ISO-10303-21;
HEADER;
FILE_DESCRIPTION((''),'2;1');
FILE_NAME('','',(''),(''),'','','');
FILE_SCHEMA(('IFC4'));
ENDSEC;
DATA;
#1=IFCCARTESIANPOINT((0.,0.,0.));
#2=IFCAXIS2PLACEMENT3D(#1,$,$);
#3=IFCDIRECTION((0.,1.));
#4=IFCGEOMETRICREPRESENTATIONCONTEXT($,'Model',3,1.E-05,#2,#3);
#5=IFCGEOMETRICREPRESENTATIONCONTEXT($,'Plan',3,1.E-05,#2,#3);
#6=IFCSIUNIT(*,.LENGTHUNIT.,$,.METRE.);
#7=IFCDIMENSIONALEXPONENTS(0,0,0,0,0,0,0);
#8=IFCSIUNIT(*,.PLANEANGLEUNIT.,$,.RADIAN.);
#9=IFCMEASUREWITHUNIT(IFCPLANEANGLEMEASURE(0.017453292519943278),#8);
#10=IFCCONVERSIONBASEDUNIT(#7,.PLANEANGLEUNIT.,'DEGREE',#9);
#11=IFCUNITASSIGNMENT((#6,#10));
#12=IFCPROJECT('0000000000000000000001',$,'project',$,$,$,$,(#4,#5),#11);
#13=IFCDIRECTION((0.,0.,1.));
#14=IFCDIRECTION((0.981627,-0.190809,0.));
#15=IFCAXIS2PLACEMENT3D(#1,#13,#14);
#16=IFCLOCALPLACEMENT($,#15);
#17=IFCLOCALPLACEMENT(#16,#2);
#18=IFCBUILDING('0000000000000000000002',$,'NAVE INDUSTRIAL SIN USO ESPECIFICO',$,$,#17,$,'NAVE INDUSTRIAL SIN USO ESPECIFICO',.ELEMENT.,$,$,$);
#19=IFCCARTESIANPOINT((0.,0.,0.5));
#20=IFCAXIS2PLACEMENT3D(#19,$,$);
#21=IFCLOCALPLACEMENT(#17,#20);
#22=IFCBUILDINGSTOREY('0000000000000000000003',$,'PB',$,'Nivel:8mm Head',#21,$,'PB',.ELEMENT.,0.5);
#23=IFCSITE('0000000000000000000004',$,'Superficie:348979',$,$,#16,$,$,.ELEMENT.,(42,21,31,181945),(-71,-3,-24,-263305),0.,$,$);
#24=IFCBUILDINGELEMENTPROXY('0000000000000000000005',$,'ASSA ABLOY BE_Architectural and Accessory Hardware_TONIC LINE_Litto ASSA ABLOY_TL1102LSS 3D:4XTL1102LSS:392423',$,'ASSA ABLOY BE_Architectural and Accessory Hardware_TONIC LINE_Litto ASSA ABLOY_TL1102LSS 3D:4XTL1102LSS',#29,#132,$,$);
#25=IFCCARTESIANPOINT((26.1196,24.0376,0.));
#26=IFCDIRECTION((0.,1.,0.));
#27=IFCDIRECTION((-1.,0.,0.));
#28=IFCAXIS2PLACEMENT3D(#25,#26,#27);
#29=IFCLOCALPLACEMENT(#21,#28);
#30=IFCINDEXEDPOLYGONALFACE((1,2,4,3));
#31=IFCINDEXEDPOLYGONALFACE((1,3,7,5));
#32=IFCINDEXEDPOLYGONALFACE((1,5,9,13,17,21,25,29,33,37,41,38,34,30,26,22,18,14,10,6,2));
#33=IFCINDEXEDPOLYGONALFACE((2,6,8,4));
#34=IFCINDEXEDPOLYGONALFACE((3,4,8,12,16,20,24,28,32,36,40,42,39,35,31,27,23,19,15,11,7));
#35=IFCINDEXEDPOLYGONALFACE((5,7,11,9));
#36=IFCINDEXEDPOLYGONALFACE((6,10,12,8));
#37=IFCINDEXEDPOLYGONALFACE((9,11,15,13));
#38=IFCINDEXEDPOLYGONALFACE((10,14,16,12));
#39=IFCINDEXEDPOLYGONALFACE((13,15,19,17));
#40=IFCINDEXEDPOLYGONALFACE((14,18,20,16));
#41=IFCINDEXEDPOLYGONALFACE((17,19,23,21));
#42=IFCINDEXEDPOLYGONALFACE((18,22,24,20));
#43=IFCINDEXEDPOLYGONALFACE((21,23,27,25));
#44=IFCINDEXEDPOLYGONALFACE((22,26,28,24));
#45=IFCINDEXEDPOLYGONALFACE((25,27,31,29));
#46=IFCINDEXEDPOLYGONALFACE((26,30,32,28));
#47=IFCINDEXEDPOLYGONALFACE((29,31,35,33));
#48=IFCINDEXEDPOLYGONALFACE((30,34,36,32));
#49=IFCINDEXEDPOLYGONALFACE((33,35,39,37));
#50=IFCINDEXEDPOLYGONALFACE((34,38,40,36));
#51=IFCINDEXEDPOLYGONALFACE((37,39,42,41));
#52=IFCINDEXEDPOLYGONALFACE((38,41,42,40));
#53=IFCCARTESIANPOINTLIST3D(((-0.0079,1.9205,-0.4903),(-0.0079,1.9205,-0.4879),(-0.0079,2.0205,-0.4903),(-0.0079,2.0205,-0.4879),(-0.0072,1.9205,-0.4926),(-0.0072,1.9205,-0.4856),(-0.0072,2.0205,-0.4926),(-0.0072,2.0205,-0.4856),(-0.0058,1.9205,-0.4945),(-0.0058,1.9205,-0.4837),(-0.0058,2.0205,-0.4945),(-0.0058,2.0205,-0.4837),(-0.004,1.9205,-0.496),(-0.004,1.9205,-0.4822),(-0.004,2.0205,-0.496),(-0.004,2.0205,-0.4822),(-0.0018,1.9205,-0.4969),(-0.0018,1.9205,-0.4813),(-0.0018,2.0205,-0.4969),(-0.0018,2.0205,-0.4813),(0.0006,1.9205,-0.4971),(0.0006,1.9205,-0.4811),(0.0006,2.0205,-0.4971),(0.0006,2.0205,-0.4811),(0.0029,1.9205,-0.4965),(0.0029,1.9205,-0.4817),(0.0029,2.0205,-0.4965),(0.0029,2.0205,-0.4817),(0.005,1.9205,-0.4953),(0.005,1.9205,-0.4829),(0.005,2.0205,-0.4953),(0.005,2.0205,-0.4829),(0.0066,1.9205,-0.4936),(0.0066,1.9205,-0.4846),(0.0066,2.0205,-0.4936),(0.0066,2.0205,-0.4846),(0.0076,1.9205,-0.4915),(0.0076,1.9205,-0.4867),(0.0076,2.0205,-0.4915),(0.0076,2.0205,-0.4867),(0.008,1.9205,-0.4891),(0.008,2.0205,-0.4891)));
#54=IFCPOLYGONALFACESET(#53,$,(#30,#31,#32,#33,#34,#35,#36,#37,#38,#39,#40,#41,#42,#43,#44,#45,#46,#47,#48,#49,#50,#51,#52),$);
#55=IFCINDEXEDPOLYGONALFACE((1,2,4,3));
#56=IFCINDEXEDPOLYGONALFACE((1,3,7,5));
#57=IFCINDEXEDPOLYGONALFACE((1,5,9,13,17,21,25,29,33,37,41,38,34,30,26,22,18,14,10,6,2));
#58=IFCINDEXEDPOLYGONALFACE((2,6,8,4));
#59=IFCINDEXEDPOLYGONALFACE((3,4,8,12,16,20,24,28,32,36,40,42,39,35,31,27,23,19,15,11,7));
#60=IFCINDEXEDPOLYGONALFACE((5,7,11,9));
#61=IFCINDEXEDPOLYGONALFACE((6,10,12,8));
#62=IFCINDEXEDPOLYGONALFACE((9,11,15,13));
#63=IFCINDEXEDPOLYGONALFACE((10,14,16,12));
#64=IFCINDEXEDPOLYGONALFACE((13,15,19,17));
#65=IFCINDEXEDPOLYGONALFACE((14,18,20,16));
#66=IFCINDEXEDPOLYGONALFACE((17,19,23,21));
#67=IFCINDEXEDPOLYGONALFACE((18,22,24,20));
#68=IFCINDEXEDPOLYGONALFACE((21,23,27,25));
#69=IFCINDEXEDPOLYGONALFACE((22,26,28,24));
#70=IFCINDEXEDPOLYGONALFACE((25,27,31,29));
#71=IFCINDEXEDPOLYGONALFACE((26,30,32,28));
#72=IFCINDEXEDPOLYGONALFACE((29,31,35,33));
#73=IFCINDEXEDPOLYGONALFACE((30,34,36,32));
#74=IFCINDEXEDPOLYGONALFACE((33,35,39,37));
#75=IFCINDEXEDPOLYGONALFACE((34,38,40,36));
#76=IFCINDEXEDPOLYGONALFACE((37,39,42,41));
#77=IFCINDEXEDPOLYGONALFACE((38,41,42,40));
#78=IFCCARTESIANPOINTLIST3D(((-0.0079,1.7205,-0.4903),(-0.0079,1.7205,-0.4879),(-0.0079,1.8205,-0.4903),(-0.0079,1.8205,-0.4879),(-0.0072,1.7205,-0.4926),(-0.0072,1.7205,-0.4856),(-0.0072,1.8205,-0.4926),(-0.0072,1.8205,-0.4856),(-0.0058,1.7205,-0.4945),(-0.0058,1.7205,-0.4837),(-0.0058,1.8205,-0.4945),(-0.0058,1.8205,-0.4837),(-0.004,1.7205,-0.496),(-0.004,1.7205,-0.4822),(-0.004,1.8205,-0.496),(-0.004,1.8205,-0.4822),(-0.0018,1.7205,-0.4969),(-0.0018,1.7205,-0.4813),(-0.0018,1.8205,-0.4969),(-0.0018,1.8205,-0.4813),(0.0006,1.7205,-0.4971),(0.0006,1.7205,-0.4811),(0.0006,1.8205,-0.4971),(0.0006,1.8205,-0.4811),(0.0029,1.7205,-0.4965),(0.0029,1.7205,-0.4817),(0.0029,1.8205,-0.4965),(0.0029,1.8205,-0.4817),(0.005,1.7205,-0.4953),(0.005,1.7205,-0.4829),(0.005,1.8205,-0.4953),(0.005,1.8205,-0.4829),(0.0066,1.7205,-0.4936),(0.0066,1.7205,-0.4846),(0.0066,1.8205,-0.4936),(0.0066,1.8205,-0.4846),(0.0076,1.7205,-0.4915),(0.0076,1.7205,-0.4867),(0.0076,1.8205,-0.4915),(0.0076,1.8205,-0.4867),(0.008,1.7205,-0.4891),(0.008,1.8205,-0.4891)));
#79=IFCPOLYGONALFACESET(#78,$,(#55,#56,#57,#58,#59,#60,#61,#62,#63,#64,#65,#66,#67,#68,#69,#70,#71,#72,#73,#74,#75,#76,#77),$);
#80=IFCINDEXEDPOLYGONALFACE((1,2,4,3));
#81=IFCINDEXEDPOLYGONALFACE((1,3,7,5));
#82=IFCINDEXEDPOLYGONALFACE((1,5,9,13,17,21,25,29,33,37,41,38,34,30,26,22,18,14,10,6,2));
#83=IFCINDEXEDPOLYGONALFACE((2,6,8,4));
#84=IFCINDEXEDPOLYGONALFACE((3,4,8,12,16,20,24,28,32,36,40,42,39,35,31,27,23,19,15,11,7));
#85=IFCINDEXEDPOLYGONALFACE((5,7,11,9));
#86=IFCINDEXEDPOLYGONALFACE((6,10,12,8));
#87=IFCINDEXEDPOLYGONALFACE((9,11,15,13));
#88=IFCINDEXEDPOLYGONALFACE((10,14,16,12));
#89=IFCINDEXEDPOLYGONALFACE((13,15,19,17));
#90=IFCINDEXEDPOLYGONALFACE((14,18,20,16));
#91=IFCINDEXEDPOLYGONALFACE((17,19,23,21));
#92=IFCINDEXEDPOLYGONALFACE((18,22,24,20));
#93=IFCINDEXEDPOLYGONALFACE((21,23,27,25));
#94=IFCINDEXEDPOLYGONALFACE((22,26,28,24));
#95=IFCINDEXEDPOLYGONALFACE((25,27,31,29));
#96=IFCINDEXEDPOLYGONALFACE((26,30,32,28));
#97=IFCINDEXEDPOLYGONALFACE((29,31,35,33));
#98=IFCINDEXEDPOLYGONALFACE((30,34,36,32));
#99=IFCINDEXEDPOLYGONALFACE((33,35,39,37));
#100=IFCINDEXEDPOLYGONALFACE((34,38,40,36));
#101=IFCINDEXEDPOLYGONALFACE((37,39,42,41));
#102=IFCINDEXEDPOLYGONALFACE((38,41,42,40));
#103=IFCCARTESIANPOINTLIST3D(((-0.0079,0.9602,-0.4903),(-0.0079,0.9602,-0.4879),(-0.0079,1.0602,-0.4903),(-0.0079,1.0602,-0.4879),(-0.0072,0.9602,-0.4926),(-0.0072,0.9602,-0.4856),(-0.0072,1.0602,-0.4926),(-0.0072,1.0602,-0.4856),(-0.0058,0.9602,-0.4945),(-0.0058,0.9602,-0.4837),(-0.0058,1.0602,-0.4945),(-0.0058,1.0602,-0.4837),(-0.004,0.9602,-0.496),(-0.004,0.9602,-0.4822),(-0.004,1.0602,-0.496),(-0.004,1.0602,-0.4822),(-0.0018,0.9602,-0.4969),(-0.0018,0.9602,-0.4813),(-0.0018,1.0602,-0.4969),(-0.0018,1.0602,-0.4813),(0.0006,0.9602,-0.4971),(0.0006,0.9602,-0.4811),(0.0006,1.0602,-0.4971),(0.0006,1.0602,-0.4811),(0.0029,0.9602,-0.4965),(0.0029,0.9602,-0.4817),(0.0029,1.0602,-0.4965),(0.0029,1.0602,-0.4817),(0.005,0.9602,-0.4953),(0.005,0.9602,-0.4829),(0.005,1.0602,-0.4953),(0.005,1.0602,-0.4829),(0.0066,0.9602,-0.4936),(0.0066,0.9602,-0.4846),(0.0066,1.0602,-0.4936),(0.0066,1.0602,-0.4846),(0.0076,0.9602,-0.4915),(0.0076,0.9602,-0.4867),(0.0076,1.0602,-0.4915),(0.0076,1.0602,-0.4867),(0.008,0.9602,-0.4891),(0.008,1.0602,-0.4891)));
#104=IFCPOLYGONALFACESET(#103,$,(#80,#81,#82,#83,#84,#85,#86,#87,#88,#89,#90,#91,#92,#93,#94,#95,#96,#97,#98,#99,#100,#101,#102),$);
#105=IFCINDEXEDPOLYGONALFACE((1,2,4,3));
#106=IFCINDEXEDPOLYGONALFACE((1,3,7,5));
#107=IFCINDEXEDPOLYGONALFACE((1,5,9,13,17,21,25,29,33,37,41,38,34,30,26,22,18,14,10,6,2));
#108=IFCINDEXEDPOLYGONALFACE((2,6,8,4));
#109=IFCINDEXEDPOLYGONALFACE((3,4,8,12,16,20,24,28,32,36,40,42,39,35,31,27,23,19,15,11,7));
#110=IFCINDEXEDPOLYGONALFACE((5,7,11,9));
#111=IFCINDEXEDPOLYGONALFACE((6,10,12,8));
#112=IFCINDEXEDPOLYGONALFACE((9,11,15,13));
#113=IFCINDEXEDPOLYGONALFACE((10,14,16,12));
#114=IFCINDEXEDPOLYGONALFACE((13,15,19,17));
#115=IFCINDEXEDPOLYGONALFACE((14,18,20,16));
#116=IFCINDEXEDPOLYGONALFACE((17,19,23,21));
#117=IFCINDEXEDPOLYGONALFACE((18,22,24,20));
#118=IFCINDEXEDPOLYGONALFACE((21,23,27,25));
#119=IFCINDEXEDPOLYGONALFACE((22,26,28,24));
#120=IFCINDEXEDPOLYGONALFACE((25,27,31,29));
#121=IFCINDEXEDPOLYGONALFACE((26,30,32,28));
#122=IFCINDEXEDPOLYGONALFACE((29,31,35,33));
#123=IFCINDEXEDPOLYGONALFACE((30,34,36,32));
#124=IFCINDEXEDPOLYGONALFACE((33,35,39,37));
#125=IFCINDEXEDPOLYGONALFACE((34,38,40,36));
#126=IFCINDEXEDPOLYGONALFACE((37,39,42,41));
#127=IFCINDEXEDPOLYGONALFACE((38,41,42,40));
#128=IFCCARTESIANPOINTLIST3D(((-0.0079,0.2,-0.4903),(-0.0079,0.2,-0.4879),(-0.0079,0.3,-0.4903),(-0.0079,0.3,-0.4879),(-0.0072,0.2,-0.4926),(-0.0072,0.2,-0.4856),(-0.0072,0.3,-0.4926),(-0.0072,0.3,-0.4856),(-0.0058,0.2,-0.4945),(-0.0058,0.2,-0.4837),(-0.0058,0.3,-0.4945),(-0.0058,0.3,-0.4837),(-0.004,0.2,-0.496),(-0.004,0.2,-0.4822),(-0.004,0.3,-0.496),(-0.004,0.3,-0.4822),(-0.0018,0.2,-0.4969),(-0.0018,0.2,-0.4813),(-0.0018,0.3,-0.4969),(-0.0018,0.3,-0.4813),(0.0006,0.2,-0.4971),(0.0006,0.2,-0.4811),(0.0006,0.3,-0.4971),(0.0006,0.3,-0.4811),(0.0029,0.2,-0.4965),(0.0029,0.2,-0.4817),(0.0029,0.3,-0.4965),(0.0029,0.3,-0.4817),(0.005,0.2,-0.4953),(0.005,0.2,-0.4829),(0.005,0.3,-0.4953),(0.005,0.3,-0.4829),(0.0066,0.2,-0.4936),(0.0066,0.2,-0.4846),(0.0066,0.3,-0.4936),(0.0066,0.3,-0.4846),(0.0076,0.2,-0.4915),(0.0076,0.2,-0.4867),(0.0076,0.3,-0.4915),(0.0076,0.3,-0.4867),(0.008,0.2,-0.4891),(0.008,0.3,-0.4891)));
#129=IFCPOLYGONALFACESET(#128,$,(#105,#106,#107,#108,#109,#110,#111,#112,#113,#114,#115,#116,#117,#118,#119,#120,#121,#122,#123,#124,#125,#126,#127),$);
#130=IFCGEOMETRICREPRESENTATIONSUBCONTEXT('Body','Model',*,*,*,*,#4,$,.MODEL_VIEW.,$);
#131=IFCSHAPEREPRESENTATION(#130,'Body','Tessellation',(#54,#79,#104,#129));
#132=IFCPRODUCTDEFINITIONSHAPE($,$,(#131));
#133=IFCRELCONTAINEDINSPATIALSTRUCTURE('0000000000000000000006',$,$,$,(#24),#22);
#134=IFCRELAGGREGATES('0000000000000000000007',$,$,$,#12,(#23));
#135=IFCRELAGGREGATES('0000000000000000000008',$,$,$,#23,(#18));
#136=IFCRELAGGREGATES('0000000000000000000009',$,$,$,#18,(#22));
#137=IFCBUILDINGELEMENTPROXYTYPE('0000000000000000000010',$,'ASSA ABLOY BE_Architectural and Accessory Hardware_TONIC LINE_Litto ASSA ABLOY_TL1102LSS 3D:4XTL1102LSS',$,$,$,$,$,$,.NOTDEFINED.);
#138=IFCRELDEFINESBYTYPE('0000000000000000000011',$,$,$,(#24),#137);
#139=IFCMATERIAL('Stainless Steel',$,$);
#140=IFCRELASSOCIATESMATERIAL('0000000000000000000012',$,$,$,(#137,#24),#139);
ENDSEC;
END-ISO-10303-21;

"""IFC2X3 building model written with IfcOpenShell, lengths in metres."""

from ifc_helpers import new_model, entity, si_unit, converted_unit, direction, frame, frame_2d, origin, place, context, subcontext, project, spatial, circle, extrude, source, transform, mapped, material, type_object, type_shapes, element, save


model = new_model("IFC2X3")

# Units and contexts
model_context = context("Model", 3, precision=1e-05, world=origin(), true_north=direction((0.0, 1.0)))
plan_context = context("Plan", 3, precision=1e-05, world=origin(), true_north=direction((0.0, 1.0)))
body_context = subcontext(model_context, "Body", "Model", "MODEL_VIEW")
ifc_project = project(units=[si_unit("LENGTHUNIT", "METRE"), converted_unit("PLANEANGLEUNIT", "DEGREE", entity("IfcPlaneAngleMeasure", 0.017453292519943278), si_unit("PLANEANGLEUNIT", "RADIAN"), dimensions=[0, 0, 0, 0, 0, 0, 0])], contexts=[model_context, plan_context])

# Site, building, storey
site_placement = place(None, frame((0.0, 0.0, 0.0), z_axis=(0.0, 0.0, 1.0), x_axis=(0.981627, -0.190809, 0.0)))
site = spatial("IfcSite", under=ifc_project, at=site_placement, Name="Superficie:348979", CompositionType="ELEMENT", RefLatitude=(42, 21, 31, 181945), RefLongitude=(-71, -3, -24, -263305), RefElevation=0.0)
building_placement = place(site_placement, origin())
building = spatial("IfcBuilding", under=site, at=building_placement, Name="NAVE INDUSTRIAL SIN USO ESPECIFICO", LongName="NAVE INDUSTRIAL SIN USO ESPECIFICO", CompositionType="ELEMENT")
storey_placement = place(building_placement, frame((0.0, 0.0, 0.5)))
storey = spatial("IfcBuildingStorey", under=building, at=storey_placement, Name="PB", ObjectType="Nivel:8mm Head", LongName="PB", CompositionType="ELEMENT", Elevation=0.5)

# Building element proxy
ifc_material_1 = material(Name="Stainless Steel")
building_element_proxy_type_1 = type_object("IfcBuildingElementProxyType", Name="ASSA ABLOY BE_Architectural and Accessory Hardware_TONIC LINE_Litto ASSA ABLOY_TL1102LSS 3D:4XTL1102LSS", PredefinedType="NOTDEFINED", material=ifc_material_1)
shared_shape_1 = source(origin(), body_context, "Body", "SweptSolid", [
    extrude(circle(Radius=0.008, at=frame_2d((0.0, 0.0), x_axis=(1.0, 0.0))), frame((0.0, 1.9205, -0.4891), z_axis=(0.0, 1.0, 0.0), x_axis=(1.0, 0.0, 0.0)), (0.0, 0.0, 1.0), 0.1),
    extrude(circle(Radius=0.008, at=frame_2d((0.0, 0.0), x_axis=(1.0, 0.0))), frame((0.0, 1.7205, -0.4891), z_axis=(0.0, 1.0, 0.0), x_axis=(1.0, 0.0, 0.0)), (0.0, 0.0, 1.0), 0.1),
    extrude(circle(Radius=0.008, at=frame_2d((0.0, 0.0), x_axis=(1.0, 0.0))), frame((0.0, 0.9602, -0.4891), z_axis=(0.0, 1.0, 0.0), x_axis=(1.0, 0.0, 0.0)), (0.0, 0.0, 1.0), 0.1),
    extrude(circle(Radius=0.008, at=frame_2d((0.0, 0.0), x_axis=(1.0, 0.0))), frame((0.0, 0.2, -0.4891), z_axis=(0.0, 1.0, 0.0), x_axis=(1.0, 0.0, 0.0)), (0.0, 0.0, 1.0), 0.1),
])
type_shapes(building_element_proxy_type_1, [shared_shape_1])
for number, where, z_axis, x_axis, name in (
    (1, (26.1196, 24.0376, 0.0), (0.0, 1.0, 0.0), (-1.0, 0.0, 0.0), "ASSA ABLOY BE_Architectural and Accessory Hardware_TONIC LINE_Litto ASSA ABLOY_TL1102LSS 3D:4XTL1102LSS:392423"),
):
    element("IfcBuildingElementProxy", number, at=place(storey_placement, frame(where, z_axis=z_axis, x_axis=x_axis)), inside=storey, type_object=building_element_proxy_type_1, material=ifc_material_1, Name=name, ObjectType="ASSA ABLOY BE_Architectural and Accessory Hardware_TONIC LINE_Litto ASSA ABLOY_TL1102LSS 3D:4XTL1102LSS", context=body_context, shape_type="MappedRepresentation", body=[
        mapped(shared_shape_1, transform((0.0, 0.0, 0.0), scale=1.0)),
    ])

save(model, "model.ifc")
